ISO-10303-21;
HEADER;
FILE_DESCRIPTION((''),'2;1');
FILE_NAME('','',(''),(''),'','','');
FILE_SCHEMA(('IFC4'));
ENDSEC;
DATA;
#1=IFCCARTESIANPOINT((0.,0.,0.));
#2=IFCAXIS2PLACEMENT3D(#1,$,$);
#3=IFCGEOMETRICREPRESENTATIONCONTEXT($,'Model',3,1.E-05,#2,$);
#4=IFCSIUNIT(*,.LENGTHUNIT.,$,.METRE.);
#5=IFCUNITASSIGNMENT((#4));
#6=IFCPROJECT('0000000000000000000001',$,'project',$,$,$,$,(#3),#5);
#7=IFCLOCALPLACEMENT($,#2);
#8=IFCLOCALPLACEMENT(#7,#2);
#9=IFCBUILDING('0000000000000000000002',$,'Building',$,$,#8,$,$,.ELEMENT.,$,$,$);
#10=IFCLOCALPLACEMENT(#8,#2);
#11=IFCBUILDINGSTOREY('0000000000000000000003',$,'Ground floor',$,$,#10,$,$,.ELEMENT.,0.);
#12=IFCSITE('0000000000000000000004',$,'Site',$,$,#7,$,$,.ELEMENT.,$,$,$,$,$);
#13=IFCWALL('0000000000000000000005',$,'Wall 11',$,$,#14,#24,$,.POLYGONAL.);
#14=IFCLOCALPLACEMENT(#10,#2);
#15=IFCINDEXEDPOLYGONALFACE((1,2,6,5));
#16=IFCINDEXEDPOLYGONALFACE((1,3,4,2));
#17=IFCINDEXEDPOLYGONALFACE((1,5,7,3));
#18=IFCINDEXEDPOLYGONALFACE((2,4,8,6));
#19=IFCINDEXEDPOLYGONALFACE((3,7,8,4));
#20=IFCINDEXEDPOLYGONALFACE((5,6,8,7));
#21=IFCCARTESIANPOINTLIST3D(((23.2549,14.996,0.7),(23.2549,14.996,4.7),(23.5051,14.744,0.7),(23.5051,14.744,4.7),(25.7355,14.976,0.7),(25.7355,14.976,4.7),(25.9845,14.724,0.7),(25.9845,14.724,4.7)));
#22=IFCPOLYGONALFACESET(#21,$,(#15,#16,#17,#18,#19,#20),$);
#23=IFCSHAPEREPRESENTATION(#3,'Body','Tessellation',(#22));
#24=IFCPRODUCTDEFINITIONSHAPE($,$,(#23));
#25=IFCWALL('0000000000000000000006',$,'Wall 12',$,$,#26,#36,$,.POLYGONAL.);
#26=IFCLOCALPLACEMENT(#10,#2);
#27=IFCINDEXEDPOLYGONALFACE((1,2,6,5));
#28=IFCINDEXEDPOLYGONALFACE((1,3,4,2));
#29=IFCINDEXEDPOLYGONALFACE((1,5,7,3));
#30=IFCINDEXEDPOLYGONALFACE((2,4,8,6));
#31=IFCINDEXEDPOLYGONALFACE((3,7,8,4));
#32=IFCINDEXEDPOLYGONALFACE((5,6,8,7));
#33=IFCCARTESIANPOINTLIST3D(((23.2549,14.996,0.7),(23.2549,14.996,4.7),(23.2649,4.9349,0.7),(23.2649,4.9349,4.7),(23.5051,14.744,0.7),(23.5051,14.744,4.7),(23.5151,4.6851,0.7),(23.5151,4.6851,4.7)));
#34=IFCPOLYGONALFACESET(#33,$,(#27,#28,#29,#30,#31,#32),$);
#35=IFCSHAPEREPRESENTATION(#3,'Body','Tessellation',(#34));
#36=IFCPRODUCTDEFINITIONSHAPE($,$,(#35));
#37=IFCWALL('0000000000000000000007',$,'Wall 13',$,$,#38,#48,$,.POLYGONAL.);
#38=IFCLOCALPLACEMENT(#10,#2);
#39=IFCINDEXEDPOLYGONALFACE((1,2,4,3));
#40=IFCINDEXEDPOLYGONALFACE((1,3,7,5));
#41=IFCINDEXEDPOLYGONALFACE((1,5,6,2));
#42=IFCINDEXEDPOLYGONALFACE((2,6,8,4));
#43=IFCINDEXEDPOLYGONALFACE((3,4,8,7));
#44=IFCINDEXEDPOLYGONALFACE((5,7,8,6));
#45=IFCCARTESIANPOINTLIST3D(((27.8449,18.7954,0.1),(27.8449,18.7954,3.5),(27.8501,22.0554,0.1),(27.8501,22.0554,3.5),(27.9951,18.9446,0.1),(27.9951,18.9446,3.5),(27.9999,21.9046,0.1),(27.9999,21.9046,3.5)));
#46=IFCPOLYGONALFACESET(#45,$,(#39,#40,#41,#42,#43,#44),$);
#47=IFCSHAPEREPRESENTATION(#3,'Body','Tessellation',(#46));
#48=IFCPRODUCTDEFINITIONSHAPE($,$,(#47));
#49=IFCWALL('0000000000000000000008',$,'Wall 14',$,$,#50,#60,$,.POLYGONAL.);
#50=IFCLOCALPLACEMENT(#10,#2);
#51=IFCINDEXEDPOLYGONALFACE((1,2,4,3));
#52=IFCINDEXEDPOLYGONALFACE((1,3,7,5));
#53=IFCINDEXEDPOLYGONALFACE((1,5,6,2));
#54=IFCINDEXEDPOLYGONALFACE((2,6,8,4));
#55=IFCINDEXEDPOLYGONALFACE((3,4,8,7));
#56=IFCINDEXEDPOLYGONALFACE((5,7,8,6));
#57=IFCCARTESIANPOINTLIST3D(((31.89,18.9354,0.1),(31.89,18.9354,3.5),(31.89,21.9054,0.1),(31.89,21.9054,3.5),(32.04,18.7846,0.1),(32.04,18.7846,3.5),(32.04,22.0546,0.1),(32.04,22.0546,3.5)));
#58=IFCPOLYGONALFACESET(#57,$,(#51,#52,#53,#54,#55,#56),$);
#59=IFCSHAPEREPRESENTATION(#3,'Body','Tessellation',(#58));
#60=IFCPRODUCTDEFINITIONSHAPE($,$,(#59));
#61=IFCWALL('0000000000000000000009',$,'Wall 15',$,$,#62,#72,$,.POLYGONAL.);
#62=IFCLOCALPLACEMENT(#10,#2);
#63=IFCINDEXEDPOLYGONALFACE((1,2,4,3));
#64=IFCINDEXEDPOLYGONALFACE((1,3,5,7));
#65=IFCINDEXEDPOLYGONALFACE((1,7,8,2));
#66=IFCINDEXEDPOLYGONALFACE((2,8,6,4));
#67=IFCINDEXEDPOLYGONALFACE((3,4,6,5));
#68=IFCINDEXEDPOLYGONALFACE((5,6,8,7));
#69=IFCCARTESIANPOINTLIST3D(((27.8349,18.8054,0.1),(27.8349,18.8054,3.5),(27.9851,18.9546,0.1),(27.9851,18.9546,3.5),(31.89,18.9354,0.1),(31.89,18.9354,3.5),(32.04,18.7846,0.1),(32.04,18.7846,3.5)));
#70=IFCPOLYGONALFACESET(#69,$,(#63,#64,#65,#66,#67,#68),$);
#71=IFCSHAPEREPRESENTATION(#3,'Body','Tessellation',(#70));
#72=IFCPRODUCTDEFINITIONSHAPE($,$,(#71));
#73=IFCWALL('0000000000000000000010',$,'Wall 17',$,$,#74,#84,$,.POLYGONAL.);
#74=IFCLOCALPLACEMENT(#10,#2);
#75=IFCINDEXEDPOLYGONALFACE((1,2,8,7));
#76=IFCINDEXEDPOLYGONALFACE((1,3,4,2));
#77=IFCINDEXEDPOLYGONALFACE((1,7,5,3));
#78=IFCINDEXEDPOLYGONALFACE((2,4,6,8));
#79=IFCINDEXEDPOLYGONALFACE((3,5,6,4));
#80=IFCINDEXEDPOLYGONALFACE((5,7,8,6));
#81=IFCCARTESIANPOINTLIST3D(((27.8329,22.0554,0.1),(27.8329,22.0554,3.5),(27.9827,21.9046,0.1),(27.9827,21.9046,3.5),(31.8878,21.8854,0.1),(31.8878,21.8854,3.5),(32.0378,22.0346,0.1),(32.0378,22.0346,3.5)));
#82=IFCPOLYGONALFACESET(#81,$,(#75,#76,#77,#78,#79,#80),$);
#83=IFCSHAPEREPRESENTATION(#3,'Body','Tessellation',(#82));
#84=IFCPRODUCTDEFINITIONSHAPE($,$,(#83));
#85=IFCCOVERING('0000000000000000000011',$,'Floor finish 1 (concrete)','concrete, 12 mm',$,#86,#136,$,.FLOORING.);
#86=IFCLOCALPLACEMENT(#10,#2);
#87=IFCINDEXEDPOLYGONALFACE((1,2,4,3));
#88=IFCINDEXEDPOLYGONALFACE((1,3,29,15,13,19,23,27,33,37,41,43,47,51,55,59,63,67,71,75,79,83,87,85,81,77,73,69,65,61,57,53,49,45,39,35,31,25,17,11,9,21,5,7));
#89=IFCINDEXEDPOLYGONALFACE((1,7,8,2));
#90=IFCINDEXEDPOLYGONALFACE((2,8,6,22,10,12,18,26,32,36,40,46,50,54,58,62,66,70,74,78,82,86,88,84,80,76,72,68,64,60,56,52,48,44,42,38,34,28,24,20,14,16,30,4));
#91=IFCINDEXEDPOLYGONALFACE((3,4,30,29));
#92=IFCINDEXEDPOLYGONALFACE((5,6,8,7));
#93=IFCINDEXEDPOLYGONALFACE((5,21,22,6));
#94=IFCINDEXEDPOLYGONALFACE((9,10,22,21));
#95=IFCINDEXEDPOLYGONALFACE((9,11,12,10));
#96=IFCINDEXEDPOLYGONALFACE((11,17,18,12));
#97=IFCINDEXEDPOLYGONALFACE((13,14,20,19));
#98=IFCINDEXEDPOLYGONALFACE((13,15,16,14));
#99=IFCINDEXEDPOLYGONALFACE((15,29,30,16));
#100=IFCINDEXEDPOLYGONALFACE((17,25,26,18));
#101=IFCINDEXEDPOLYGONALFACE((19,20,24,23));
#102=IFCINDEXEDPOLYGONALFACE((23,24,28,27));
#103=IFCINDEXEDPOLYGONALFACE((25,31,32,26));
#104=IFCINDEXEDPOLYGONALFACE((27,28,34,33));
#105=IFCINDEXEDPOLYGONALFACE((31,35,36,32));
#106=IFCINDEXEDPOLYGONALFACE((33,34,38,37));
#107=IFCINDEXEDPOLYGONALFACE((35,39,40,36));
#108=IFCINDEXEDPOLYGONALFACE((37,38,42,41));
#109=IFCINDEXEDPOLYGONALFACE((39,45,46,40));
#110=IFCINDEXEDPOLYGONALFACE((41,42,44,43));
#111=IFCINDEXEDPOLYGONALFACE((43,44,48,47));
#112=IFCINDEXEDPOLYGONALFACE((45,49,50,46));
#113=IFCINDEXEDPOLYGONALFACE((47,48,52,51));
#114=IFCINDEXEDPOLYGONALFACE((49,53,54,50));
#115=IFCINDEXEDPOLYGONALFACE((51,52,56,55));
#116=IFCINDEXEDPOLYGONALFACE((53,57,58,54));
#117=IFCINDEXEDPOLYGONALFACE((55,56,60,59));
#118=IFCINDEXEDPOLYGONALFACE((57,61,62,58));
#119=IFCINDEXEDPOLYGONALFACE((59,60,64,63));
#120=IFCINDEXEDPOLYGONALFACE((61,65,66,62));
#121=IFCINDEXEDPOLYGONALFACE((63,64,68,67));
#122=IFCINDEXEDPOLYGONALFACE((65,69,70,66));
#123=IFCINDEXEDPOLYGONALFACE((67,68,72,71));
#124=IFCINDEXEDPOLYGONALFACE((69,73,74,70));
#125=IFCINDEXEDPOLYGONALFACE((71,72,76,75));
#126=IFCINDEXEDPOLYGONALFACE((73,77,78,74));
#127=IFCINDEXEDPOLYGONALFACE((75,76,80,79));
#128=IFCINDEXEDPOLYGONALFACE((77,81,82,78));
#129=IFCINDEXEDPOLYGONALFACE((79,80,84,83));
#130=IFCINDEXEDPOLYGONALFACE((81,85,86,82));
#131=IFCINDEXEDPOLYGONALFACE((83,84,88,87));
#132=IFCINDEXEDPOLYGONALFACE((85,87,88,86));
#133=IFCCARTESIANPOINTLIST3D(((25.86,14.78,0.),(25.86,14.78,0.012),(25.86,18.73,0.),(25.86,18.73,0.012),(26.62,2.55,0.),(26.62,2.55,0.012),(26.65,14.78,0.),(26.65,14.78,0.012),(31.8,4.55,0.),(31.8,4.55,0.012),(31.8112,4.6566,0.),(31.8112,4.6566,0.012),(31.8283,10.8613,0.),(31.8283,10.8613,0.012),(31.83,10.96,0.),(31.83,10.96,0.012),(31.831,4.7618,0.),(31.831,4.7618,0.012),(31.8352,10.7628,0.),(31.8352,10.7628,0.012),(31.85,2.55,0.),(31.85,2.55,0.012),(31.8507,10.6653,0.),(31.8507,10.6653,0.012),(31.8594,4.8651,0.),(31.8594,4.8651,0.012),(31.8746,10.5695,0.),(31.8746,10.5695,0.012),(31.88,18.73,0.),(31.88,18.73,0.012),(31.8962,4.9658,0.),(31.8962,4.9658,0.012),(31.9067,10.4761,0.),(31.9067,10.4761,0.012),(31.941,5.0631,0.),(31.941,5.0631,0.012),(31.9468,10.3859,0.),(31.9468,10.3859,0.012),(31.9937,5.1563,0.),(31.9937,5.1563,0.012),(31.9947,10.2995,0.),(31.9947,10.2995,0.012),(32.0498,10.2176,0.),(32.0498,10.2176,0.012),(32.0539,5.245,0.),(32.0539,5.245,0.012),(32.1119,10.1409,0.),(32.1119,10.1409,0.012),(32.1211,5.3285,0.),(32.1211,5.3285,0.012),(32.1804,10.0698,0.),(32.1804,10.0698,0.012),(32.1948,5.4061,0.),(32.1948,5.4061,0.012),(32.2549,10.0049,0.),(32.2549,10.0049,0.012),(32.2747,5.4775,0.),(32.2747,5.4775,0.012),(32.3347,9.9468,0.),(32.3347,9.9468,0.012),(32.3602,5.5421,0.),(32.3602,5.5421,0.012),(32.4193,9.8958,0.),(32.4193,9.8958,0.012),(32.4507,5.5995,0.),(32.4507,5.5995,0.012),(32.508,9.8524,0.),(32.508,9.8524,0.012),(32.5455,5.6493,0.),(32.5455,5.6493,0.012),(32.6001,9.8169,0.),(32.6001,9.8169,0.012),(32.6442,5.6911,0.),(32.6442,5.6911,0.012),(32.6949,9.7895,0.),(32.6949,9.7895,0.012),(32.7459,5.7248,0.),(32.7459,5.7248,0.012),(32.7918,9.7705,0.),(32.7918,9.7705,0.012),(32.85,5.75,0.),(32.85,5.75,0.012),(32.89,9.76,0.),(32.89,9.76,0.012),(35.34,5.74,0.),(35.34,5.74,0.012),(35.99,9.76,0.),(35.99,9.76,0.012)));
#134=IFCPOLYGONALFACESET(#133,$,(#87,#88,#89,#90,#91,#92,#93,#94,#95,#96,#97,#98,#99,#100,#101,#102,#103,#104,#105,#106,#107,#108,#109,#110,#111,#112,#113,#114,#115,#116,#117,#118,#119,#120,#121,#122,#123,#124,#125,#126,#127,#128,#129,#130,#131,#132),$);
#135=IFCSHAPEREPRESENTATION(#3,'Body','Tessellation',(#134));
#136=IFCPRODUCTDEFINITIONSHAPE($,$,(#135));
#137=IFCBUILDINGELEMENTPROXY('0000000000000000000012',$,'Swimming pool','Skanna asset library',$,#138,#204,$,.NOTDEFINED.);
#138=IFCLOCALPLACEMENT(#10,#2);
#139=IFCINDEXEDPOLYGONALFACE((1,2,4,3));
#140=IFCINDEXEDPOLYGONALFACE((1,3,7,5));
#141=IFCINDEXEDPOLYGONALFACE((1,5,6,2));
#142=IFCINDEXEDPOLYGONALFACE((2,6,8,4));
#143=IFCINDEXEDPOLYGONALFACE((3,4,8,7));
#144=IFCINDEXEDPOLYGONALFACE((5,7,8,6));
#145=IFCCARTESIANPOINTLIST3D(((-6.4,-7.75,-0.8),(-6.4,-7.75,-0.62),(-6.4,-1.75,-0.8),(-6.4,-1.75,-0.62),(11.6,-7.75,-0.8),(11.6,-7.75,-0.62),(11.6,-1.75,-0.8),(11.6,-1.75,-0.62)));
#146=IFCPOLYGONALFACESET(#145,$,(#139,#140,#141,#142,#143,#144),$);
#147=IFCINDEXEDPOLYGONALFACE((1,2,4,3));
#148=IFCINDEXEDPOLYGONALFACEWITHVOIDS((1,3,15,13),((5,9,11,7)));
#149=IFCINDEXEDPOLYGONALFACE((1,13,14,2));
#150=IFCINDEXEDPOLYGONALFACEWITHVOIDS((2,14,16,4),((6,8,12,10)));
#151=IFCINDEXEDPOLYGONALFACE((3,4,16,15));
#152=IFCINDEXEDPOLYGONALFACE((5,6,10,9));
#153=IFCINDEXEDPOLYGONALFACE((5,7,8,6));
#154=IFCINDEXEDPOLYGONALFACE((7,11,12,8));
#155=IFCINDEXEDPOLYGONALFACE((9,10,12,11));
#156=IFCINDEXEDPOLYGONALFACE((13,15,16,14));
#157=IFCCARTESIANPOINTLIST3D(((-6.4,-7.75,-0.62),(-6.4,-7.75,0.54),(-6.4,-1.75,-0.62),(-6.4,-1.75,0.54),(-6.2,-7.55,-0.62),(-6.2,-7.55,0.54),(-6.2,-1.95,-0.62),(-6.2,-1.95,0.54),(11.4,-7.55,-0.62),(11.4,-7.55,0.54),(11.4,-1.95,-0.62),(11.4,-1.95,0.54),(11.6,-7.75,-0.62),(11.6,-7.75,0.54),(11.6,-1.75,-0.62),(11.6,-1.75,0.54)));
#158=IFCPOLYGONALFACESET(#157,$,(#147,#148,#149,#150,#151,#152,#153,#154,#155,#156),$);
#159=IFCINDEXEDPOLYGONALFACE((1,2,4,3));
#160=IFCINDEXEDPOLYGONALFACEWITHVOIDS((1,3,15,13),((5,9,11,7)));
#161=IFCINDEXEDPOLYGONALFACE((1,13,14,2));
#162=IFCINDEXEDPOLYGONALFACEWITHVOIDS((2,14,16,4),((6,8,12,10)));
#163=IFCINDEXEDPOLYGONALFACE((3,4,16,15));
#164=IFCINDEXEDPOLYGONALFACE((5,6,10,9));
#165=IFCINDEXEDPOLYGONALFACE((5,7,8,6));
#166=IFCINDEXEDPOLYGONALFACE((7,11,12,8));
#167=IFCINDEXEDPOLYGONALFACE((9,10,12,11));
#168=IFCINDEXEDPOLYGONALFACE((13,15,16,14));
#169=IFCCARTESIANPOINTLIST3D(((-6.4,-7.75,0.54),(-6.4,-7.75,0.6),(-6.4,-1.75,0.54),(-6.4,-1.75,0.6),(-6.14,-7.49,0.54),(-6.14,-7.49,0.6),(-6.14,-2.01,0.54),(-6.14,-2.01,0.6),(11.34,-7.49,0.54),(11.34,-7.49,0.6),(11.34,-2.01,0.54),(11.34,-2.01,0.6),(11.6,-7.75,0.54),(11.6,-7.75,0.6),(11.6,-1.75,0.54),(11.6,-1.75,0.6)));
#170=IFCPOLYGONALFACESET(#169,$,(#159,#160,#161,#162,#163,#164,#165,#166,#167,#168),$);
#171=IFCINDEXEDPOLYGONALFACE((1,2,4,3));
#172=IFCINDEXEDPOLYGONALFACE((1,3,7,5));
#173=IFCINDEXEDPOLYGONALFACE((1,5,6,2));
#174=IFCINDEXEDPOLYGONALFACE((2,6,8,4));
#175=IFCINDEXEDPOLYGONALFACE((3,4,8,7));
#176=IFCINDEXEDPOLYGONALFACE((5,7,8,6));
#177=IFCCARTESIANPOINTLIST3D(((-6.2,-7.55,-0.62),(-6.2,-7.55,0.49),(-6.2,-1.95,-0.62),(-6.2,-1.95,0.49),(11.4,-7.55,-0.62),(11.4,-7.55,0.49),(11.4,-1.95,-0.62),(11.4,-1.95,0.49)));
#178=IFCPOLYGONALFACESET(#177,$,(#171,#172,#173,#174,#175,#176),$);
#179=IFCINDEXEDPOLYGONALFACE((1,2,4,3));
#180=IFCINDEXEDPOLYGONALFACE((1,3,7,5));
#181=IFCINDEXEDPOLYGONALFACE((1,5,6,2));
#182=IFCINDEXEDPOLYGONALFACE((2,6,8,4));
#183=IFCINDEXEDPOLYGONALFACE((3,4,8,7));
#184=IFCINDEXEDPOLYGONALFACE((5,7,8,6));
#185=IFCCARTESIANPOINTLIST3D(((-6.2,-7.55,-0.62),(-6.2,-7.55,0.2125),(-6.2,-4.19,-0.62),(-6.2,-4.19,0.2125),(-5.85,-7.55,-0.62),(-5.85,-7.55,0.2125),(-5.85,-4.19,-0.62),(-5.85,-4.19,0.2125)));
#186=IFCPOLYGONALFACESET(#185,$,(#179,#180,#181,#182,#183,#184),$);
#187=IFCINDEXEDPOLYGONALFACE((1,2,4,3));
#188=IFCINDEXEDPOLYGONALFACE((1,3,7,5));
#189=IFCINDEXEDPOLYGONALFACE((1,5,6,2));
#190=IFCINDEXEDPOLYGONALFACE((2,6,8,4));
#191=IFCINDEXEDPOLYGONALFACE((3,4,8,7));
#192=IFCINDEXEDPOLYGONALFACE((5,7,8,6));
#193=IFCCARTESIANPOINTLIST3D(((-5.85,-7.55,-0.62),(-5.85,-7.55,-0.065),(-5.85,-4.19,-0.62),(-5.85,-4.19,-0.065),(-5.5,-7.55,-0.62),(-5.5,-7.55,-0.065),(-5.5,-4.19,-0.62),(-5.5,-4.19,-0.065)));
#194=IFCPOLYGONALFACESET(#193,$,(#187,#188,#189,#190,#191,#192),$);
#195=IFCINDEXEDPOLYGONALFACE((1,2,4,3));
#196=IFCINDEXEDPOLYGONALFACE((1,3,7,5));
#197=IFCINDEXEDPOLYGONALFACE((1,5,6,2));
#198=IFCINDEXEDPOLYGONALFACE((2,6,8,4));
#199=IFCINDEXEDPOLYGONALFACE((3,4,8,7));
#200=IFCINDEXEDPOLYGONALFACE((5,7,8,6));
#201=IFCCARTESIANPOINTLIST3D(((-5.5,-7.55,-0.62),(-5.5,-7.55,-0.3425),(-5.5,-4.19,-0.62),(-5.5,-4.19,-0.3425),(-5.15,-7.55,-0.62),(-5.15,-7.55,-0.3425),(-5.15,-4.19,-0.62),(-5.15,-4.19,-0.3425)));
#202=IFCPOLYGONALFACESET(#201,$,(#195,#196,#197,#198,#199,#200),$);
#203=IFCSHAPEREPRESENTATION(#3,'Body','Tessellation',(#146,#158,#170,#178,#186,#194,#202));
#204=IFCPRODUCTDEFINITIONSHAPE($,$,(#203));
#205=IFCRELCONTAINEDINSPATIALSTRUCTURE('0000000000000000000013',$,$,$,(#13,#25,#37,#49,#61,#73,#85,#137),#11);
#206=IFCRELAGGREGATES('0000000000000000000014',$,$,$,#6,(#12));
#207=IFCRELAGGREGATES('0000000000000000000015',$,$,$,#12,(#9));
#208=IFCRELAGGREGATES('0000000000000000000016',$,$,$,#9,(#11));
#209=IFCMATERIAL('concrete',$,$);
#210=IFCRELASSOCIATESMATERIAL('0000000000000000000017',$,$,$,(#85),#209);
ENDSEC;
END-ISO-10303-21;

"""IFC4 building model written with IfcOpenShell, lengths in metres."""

from ifc_helpers import new_model, si_unit, frame, frame_2d, origin, origin_with_axes, origin_2d, place, context, project, spatial, polyline, rectangle, outline, extrude, material, element, save


model = new_model("IFC4")

# Units and contexts
model_context = context("Model", 3, precision=1e-05, world=origin())
ifc_project = project(units=[si_unit("LENGTHUNIT", "METRE")], contexts=[model_context])

# Site, building, storey
site_placement = place(None, origin())
site = spatial("IfcSite", under=ifc_project, at=site_placement, Name="Site", CompositionType="ELEMENT")
building_placement = place(site_placement, origin())
building = spatial("IfcBuilding", under=site, at=building_placement, Name="Building", CompositionType="ELEMENT")
storey_placement = place(building_placement, origin())
storey = spatial("IfcBuildingStorey", under=building, at=storey_placement, Name="Ground floor", CompositionType="ELEMENT", Elevation=0.0)

# Walls
wall_1_placement = place(storey_placement, frame((0.0, 0.0, 0.7), z_axis=(0.0, 0.0, 1.0), x_axis=(1.0, 0.0, 0.0)))
element("IfcWall", 1, at=wall_1_placement, inside=storey, Name="Wall 11", PredefinedType="POLYGONAL", context=model_context, shape_type="SweptSolid", body=[
    extrude(outline(polyline([(25.9845, 14.724), (25.7355, 14.976), (23.2549, 14.996), (23.5051, 14.744), (25.9845, 14.724)])), origin(), (0.0, 0.0, 1.0), 4.0),
])
wall_2_placement = place(storey_placement, frame((0.0, 0.0, 0.7), z_axis=(0.0, 0.0, 1.0), x_axis=(1.0, 0.0, 0.0)))
element("IfcWall", 2, at=wall_2_placement, inside=storey, Name="Wall 12", PredefinedType="POLYGONAL", context=model_context, shape_type="SweptSolid", body=[
    extrude(outline(polyline([(23.2649, 4.9349), (23.5151, 4.6851), (23.5051, 14.744), (23.2549, 14.996), (23.2649, 4.9349)])), origin(), (0.0, 0.0, 1.0), 4.0),
])
wall_3_placement = place(storey_placement, frame((0.0, 0.0, 0.1), z_axis=(0.0, 0.0, 1.0), x_axis=(1.0, 0.0, 0.0)))
element("IfcWall", 3, at=wall_3_placement, inside=storey, Name="Wall 13", PredefinedType="POLYGONAL", context=model_context, shape_type="SweptSolid", body=[
    extrude(outline(polyline([(27.8449, 18.7954), (27.9951, 18.9446), (27.9999, 21.9046), (27.8501, 22.0554), (27.8449, 18.7954)])), origin(), (0.0, 0.0, 1.0), 3.4),
])
wall_4_placement = place(storey_placement, frame((0.0, 0.0, 0.1), z_axis=(0.0, 0.0, 1.0), x_axis=(1.0, 0.0, 0.0)))
element("IfcWall", 4, at=wall_4_placement, inside=storey, Name="Wall 14", PredefinedType="POLYGONAL", context=model_context, shape_type="SweptSolid", body=[
    extrude(outline(polyline([(31.89, 18.9354), (32.04, 18.7846), (32.04, 22.0546), (31.89, 21.9054), (31.89, 18.9354)])), origin(), (0.0, 0.0, 1.0), 3.4),
])
wall_5_placement = place(storey_placement, frame((0.0, 0.0, 0.1), z_axis=(0.0, 0.0, 1.0), x_axis=(1.0, 0.0, 0.0)))
element("IfcWall", 5, at=wall_5_placement, inside=storey, Name="Wall 15", PredefinedType="POLYGONAL", context=model_context, shape_type="SweptSolid", body=[
    extrude(outline(polyline([(32.04, 18.7846), (31.89, 18.9354), (27.9851, 18.9546), (27.8349, 18.8054), (32.04, 18.7846)])), origin(), (0.0, 0.0, 1.0), 3.4),
])
wall_6_placement = place(storey_placement, frame((0.0, 0.0, 0.1), z_axis=(0.0, 0.0, 1.0), x_axis=(1.0, 0.0, 0.0)))
element("IfcWall", 6, at=wall_6_placement, inside=storey, Name="Wall 17", PredefinedType="POLYGONAL", context=model_context, shape_type="SweptSolid", body=[
    extrude(outline(polyline([(31.8878, 21.8854), (32.0378, 22.0346), (27.8329, 22.0554), (27.9827, 21.9046), (31.8878, 21.8854)])), origin(), (0.0, 0.0, 1.0), 3.4),
])

# Covering
ifc_material = material(Name="concrete")
covering_placement = place(storey_placement, origin_with_axes())
element("IfcCovering", 7, at=covering_placement, inside=storey, material=ifc_material, Name="Floor finish 1 (concrete)", Description="concrete, 12 mm", PredefinedType="FLOORING", context=model_context, shape_type="SweptSolid", body=[
    extrude(outline(polyline([(35.34, 5.74), (32.85, 5.75), (32.7459, 5.7248), (32.6442, 5.6911), (32.5455, 5.6493), (32.4507, 5.5995), (32.3602, 5.5421), (32.2747, 5.4775), (32.1948, 5.4061), (32.1211, 5.3285), (32.0539, 5.245), (31.9937, 5.1563), (31.9411, 5.0631), (31.8962, 4.9658), (31.8594, 4.8651), (31.831, 4.7618), (31.8112, 4.6566), (31.8, 4.55), (31.85, 2.55), (26.62, 2.55), (26.65, 14.78), (25.86, 14.78), (25.86, 18.73), (31.88, 18.73), (31.83, 10.96), (31.8283, 10.8613), (31.8352, 10.7628), (31.8507, 10.6653), (31.8746, 10.5695), (31.9067, 10.4761), (31.9468, 10.3859), (31.9947, 10.2995), (32.0498, 10.2176), (32.1119, 10.1409), (32.1805, 10.0698), (32.2549, 10.0049), (32.3347, 9.9468), (32.4193, 9.8958), (32.508, 9.8524), (32.6001, 9.8169), (32.6949, 9.7895), (32.7918, 9.7705), (32.89, 9.76), (35.99, 9.76), (35.34, 5.74)])), origin(), (0.0, 0.0, 1.0), 0.012),
])

# Building element proxy
proxy_placement = place(storey_placement, frame((2.6, -4.75, -0.8), z_axis=(0.0, 0.0, 1.0), x_axis=(1.0, 0.0, 0.0)))
element("IfcBuildingElementProxy", 8, at=proxy_placement, inside=storey, Name="Swimming pool", Description="Skanna asset library", PredefinedType="NOTDEFINED", context=model_context, shape_type="SweptSolid", body=[
    extrude(rectangle(XDim=18.0, YDim=6.0, at=origin_2d()), origin(), (0.0, 0.0, 1.0), 0.18),
    extrude(outline(polyline([(-9.0, -3.0), (9.0, -3.0), (9.0, 3.0), (-9.0, 3.0), (-9.0, -3.0)]), holes=[polyline([(-8.8, -2.8), (8.8, -2.8), (8.8, 2.8), (-8.8, 2.8), (-8.8, -2.8)])]), frame((0.0, 0.0, 0.18)), (0.0, 0.0, 1.0), 1.16),
    extrude(outline(polyline([(-9.0, -3.0), (9.0, -3.0), (9.0, 3.0), (-9.0, 3.0), (-9.0, -3.0)]), holes=[polyline([(-8.74, -2.74), (8.74, -2.74), (8.74, 2.74), (-8.74, 2.74), (-8.74, -2.74)])]), frame((0.0, 0.0, 1.34)), (0.0, 0.0, 1.0), 0.06),
    extrude(rectangle(XDim=17.6, YDim=5.6, at=origin_2d()), frame((0.0, 0.0, 0.18)), (0.0, 0.0, 1.0), 1.11),
    extrude(rectangle(XDim=0.35, YDim=3.36, at=frame_2d((-8.625, -1.12))), frame((0.0, 0.0, 0.18)), (0.0, 0.0, 1.0), 0.8325),
    extrude(rectangle(XDim=0.35, YDim=3.36, at=frame_2d((-8.275, -1.12))), frame((0.0, 0.0, 0.18)), (0.0, 0.0, 1.0), 0.555),
    extrude(rectangle(XDim=0.35, YDim=3.36, at=frame_2d((-7.925, -1.12))), frame((0.0, 0.0, 0.18)), (0.0, 0.0, 1.0), 0.2775),
])

save(model, "model.ifc")
